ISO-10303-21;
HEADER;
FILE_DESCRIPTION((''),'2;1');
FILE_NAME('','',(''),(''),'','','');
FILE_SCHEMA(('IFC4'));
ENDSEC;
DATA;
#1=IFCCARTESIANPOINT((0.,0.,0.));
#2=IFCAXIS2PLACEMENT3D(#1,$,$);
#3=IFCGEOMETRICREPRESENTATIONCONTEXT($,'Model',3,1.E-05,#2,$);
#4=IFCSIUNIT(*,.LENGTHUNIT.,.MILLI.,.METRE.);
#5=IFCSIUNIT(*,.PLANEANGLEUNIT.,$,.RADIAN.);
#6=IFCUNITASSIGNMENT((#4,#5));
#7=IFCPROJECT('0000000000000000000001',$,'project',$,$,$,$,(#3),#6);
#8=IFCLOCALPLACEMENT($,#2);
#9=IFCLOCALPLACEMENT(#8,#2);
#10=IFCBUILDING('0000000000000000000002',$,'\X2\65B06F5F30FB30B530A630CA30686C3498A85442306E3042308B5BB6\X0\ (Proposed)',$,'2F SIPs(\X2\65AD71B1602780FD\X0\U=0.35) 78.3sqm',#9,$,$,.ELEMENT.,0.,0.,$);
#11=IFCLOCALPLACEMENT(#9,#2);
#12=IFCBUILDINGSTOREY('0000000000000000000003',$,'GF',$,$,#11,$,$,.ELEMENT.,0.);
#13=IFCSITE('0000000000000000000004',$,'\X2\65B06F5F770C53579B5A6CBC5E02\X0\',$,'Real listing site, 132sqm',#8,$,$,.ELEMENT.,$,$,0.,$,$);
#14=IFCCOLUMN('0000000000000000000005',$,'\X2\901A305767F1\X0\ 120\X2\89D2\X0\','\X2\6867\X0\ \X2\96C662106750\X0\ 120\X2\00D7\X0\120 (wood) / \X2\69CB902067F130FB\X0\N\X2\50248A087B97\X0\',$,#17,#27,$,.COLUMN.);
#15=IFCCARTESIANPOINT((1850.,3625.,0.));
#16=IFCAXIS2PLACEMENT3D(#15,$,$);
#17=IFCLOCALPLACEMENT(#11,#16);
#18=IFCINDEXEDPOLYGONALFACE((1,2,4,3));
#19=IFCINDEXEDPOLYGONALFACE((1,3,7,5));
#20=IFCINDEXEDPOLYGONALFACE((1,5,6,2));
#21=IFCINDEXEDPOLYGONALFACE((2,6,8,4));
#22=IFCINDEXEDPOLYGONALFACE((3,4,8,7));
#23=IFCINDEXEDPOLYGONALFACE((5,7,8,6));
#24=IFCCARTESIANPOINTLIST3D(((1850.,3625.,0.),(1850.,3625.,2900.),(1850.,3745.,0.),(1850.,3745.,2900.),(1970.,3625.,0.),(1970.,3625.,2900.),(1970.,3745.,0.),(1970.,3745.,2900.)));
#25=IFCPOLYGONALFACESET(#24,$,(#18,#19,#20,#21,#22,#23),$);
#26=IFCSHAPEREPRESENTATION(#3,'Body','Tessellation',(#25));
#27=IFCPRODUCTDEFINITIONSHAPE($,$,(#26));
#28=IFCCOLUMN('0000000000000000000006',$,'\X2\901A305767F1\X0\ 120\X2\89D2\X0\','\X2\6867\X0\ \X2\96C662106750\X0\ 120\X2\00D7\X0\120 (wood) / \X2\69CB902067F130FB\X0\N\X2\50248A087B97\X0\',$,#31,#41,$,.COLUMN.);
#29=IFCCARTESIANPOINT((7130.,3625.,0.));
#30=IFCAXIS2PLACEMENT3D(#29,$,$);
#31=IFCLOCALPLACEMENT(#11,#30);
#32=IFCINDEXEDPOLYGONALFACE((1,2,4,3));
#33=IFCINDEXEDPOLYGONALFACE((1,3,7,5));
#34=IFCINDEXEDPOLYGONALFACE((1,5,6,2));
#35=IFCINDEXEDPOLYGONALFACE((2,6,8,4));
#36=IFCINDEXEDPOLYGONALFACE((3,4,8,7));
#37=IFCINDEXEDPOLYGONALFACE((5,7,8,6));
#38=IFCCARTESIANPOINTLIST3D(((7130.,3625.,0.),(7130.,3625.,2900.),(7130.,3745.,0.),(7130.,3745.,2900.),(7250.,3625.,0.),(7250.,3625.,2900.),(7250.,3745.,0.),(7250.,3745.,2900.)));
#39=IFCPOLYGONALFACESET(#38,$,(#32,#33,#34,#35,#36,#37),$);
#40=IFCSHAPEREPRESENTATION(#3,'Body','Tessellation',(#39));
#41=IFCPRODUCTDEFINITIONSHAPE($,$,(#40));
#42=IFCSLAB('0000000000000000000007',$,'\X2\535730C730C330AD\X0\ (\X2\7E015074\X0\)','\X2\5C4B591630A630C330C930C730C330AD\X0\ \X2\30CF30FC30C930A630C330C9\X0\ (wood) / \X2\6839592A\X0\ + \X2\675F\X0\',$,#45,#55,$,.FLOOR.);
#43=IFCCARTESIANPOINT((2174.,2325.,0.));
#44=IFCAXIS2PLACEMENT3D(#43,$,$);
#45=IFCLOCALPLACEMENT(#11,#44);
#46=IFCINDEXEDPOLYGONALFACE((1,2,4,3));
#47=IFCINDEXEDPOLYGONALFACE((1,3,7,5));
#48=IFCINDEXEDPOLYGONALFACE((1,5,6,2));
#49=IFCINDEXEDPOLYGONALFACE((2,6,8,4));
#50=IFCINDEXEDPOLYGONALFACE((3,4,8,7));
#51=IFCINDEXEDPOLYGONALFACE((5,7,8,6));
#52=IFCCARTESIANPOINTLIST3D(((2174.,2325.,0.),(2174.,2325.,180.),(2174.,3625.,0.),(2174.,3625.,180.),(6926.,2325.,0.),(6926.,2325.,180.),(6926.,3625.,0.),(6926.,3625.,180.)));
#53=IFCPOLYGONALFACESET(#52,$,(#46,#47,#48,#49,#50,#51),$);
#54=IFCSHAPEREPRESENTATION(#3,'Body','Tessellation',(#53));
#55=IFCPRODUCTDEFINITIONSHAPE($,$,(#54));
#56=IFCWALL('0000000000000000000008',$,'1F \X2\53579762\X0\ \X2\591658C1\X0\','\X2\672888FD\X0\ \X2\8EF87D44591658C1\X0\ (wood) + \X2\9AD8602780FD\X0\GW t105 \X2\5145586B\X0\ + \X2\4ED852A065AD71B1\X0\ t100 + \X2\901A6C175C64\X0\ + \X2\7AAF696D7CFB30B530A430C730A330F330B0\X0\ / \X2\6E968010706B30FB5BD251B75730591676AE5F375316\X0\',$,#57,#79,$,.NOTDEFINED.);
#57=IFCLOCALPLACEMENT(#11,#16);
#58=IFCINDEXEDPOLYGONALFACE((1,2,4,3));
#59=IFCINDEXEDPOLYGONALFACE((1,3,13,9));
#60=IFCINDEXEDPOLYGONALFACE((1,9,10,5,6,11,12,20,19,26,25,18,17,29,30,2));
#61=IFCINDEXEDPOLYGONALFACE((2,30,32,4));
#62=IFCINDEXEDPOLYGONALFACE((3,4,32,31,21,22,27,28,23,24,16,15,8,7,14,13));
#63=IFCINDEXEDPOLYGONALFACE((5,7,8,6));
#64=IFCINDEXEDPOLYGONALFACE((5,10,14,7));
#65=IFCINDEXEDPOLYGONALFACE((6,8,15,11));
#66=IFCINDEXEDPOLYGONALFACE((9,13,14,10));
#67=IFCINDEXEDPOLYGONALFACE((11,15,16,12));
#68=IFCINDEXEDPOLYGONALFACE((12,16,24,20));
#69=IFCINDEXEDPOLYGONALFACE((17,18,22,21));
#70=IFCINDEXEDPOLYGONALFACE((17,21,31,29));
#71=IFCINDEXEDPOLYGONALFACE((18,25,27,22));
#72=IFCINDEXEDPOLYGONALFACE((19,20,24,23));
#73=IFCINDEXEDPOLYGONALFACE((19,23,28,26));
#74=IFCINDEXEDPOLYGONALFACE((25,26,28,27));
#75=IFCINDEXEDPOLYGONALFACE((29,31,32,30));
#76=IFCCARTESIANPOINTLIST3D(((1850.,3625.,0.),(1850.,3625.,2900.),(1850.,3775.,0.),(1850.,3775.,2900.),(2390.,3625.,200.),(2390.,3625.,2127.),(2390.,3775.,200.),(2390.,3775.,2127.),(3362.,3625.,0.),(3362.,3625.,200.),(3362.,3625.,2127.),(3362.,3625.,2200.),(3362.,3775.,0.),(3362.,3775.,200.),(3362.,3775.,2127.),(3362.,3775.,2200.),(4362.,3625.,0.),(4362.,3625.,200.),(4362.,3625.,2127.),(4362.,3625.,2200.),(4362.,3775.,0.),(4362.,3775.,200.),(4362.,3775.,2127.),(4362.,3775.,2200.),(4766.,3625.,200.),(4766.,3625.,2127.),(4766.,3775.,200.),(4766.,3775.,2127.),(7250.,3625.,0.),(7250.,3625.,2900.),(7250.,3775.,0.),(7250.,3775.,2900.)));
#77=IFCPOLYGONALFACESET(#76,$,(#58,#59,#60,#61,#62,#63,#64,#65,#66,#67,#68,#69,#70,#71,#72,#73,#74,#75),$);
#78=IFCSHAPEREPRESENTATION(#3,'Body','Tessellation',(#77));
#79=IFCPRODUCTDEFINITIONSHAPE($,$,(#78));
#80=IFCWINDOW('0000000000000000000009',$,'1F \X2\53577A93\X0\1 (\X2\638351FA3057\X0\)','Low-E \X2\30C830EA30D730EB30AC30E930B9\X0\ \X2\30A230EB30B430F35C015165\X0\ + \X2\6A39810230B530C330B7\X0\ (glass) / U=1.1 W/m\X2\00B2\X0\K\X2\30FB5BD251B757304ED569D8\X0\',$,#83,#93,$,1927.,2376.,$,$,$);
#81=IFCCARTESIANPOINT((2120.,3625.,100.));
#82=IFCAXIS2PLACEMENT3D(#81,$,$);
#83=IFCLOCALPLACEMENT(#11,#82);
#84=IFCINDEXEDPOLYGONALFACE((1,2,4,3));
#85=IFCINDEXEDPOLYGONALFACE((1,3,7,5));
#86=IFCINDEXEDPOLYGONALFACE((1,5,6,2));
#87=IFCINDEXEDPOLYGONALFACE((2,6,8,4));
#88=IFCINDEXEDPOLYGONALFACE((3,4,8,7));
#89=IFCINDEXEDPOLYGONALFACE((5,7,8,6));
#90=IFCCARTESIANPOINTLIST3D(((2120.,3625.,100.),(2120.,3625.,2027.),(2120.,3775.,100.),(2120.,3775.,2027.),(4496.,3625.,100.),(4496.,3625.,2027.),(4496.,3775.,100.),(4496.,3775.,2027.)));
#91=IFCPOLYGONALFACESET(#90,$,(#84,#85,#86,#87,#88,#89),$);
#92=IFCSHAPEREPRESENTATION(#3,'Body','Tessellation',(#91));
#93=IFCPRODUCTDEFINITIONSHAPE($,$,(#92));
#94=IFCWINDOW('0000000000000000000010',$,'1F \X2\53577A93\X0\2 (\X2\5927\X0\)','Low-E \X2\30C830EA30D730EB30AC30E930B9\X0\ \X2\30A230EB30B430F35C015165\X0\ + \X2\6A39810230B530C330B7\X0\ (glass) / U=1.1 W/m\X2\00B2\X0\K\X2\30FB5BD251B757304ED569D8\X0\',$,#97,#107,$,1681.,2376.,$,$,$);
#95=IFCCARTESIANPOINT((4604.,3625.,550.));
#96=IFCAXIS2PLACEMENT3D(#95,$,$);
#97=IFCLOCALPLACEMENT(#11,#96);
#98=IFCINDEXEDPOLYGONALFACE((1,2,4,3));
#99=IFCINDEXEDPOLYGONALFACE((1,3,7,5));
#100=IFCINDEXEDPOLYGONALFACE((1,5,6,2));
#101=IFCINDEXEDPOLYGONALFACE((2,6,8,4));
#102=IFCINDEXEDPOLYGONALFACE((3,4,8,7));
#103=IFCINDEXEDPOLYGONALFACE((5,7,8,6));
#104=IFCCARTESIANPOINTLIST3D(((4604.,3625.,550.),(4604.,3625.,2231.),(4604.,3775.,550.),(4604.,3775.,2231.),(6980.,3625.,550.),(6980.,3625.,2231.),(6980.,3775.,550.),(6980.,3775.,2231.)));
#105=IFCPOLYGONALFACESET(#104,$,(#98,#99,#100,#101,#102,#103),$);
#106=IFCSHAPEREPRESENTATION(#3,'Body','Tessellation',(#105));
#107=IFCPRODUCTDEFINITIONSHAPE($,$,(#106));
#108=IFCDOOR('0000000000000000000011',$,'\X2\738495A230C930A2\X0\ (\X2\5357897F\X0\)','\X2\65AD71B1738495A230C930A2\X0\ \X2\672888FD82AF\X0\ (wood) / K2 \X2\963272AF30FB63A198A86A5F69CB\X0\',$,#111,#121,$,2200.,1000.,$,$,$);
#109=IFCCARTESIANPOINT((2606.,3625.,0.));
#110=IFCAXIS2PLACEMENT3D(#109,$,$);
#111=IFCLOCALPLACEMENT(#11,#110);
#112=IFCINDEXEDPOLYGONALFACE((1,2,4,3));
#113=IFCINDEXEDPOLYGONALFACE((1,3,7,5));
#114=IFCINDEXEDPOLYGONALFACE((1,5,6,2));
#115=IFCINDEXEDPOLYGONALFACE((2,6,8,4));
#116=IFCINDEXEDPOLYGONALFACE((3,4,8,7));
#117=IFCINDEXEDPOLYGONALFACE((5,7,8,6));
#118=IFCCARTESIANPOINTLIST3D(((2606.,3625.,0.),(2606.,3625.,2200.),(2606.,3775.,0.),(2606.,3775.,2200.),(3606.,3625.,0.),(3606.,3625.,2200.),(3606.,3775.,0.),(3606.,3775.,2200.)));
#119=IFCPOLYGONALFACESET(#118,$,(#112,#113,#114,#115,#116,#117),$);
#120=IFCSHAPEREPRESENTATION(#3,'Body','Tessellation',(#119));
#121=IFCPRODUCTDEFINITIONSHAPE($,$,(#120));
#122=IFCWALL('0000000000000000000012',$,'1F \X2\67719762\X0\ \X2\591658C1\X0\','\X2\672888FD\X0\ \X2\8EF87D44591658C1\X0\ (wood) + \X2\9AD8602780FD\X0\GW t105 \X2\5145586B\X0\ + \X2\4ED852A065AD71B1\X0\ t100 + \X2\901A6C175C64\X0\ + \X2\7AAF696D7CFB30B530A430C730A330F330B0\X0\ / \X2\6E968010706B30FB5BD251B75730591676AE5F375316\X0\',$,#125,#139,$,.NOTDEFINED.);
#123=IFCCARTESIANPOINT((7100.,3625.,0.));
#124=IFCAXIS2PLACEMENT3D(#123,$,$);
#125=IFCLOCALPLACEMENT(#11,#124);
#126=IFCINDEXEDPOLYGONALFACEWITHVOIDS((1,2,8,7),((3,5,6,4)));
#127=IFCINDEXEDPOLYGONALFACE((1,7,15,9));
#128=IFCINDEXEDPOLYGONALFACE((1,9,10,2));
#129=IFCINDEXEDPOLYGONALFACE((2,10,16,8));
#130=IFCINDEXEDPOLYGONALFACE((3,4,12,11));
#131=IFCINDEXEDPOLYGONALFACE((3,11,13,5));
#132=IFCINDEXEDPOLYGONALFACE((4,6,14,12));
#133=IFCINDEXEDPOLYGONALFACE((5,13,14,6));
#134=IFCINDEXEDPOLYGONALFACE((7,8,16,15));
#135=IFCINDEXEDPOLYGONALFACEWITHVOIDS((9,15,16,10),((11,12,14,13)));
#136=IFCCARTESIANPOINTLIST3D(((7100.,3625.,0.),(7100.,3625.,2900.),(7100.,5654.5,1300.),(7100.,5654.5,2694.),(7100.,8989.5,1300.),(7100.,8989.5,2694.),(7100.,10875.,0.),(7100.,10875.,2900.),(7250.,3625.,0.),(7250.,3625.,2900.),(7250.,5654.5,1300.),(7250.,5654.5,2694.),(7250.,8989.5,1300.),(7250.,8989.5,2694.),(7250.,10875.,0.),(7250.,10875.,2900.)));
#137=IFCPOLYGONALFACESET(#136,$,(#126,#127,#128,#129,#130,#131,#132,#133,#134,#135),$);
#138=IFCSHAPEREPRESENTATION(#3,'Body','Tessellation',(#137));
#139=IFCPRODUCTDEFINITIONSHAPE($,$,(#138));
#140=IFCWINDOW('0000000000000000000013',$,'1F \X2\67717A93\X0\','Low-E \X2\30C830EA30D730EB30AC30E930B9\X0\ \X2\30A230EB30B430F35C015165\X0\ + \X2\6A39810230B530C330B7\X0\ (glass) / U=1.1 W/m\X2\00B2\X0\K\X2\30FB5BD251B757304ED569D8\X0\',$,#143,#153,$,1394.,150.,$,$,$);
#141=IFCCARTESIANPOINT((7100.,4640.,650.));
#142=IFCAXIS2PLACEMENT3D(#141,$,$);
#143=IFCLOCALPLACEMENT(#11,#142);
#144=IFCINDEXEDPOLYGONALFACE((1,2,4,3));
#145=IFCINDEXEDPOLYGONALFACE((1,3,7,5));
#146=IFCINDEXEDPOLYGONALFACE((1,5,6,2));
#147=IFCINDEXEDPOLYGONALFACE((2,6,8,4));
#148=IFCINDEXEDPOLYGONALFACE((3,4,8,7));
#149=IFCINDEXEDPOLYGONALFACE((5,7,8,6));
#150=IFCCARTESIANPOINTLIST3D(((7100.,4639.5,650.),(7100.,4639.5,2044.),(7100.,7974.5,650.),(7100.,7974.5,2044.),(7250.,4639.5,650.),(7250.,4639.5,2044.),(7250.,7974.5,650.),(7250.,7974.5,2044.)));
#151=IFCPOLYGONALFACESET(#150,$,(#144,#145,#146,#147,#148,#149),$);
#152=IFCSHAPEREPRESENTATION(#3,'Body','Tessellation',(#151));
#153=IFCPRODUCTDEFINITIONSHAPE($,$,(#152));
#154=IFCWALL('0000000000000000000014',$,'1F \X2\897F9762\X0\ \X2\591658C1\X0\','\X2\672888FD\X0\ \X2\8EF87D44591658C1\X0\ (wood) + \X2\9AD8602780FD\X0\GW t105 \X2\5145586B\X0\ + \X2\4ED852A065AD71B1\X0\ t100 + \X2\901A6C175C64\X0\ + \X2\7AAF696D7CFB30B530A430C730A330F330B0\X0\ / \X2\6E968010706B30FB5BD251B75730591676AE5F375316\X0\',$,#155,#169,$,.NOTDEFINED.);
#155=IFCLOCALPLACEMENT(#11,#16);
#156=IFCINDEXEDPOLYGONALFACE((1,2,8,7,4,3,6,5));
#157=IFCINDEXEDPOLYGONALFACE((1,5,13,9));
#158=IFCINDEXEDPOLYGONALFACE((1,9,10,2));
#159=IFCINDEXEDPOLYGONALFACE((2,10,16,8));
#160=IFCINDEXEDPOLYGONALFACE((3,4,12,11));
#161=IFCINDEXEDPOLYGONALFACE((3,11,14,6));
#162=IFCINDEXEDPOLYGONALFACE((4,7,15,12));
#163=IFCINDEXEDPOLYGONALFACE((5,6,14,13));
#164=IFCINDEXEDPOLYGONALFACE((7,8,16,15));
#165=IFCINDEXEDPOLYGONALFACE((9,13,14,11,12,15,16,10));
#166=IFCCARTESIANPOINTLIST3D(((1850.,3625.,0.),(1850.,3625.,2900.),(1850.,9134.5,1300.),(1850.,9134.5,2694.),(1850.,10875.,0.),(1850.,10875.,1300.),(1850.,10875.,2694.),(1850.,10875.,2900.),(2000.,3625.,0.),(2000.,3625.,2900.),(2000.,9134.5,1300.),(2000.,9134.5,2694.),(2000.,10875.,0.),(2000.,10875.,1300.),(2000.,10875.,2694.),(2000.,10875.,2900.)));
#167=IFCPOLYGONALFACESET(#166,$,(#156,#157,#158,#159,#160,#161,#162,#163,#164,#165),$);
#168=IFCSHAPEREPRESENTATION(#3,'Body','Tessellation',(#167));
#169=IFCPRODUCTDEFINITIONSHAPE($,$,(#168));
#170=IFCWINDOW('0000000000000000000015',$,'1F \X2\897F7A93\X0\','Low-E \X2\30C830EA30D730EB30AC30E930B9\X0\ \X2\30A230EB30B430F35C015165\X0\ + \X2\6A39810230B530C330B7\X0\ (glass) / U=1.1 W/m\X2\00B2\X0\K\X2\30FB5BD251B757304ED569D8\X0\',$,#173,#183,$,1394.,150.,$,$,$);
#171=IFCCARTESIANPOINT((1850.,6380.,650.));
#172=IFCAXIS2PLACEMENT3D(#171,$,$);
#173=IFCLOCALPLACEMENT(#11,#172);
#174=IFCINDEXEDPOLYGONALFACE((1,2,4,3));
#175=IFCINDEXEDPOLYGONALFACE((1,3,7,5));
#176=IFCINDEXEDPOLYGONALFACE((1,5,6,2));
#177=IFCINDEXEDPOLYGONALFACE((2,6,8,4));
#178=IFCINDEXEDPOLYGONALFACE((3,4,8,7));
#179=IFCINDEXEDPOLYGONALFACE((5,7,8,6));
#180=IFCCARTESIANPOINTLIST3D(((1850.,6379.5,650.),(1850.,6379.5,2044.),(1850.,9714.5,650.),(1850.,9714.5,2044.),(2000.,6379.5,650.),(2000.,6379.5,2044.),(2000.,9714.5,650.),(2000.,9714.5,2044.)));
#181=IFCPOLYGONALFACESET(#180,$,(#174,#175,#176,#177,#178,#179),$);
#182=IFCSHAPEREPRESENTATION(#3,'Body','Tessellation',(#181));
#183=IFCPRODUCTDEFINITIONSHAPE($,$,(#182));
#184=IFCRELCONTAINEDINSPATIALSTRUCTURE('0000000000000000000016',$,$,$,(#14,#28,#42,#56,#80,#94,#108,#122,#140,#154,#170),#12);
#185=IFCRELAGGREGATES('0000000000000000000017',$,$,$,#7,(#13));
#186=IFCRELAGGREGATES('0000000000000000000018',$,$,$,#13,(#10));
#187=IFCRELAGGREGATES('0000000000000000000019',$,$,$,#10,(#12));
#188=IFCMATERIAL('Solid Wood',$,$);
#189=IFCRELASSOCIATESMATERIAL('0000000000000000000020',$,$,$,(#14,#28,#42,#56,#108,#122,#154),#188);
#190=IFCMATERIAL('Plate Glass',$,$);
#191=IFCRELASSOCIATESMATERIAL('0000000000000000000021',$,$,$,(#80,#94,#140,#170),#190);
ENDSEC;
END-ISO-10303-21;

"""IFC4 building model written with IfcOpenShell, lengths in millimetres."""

from ifc_helpers import new_model, si_unit, frame, frame_2d, origin, place, context, project, spatial, rectangle, extrude, material, element, fill, save


model = new_model("IFC4")

# Units and contexts
model_context = context("Model", 3, precision=1e-05, world=origin())
ifc_project = project(units=[si_unit("LENGTHUNIT", "METRE", prefix="MILLI"), si_unit("PLANEANGLEUNIT", "RADIAN")], contexts=[model_context])

# Site, building, storey
site_placement = place(None, origin())
site = spatial("IfcSite", under=ifc_project, at=site_placement, Name="新潟県南魚沼市", ObjectType="Real listing site, 132sqm", CompositionType="ELEMENT", RefElevation=0.0)
building_placement = place(site_placement, origin())
building = spatial("IfcBuilding", under=site, at=building_placement, Name="新潟・サウナと水風呂のある家 (Proposed)", ObjectType="2F SIPs(断熱性能U=0.35) 78.3sqm", CompositionType="ELEMENT", ElevationOfRefHeight=0.0, ElevationOfTerrain=0.0)
storey_placement = place(building_placement, origin())
storey = spatial("IfcBuildingStorey", under=building, at=storey_placement, Name="GF", CompositionType="ELEMENT", Elevation=0.0)

# Columns
ifc_material_1 = material(Name="Solid Wood")
column_1_placement = place(storey_placement, frame((1850.0, 3625.0, 0.0)))
element("IfcColumn", 1, at=column_1_placement, inside=storey, material=ifc_material_1, Name="通し柱 120角", Description="桧 集成材 120×120 (wood) / 構造柱・N値計算", PredefinedType="COLUMN", context=model_context, shape_type="SweptSolid", body=[
    extrude(rectangle(XDim=120.0, YDim=120.0, at=frame_2d((60.0, 60.0))), frame((1850.0, 3625.0, 0.0)), (0.0, 0.0, 1.0), 2900.0),
])
column_2_placement = place(storey_placement, frame((7130.0, 3625.0, 0.0)))
element("IfcColumn", 2, at=column_2_placement, inside=storey, material=ifc_material_1, Name="通し柱 120角", Description="桧 集成材 120×120 (wood) / 構造柱・N値計算", PredefinedType="COLUMN", context=model_context, shape_type="SweptSolid", body=[
    extrude(rectangle(XDim=120.0, YDim=120.0, at=frame_2d((60.0, 60.0))), frame((7130.0, 3625.0, 0.0)), (0.0, 0.0, 1.0), 2900.0),
])

# Slab
slab_1_placement = place(storey_placement, frame((2174.0, 2325.0, 0.0)))
element("IfcSlab", 3, at=slab_1_placement, inside=storey, material=ifc_material_1, Name="南デッキ (縁側)", Description="屋外ウッドデッキ ハードウッド (wood) / 根太 + 束", PredefinedType="FLOOR", context=model_context, shape_type="SweptSolid", body=[
    extrude(rectangle(XDim=4752.0, YDim=1300.0, at=frame_2d((2376.0, 650.0))), frame((2174.0, 2325.0, 0.0)), (0.0, 0.0, 1.0), 180.0),
])

# Wall, openings, windows, door
wall_1_placement = place(storey_placement, frame((1850.0, 3625.0, 0.0)))
wall_1 = element("IfcWall", 4, at=wall_1_placement, inside=storey, material=ifc_material_1, Name="1F 南面 外壁", Description="木製 軸組外壁 (wood) + 高性能GW t105 充填 + 付加断熱 t100 + 通気層 + 窯業系サイディング / 準耐火・寒冷地外皮強化", PredefinedType="NOTDEFINED", context=model_context, shape_type="SweptSolid", body=[
    extrude(rectangle(XDim=5400.0, YDim=150.0, at=frame_2d((2700.0, 75.0))), frame((1850.0, 3625.0, 0.0)), (0.0, 0.0, 1.0), 2900.0),
])
opening_1_placement = place(storey_placement, frame((2120.0, 3625.0, 100.0)))
opening_1 = element("IfcOpeningElement", 5, at=opening_1_placement, cuts=wall_1, PredefinedType="NOTDEFINED", context=model_context, shape_type="SweptSolid", body=[
    extrude(rectangle(XDim=2376.0, YDim=150.0, at=frame_2d((1188.0, 75.0))), frame((2120.0, 3625.0, 100.0)), (0.0, 0.0, 1.0), 1927.0),
])
opening_2_placement = place(storey_placement, frame((4604.0, 3625.0, 550.0)))
opening_2 = element("IfcOpeningElement", 6, at=opening_2_placement, cuts=wall_1, PredefinedType="NOTDEFINED", context=model_context, shape_type="SweptSolid", body=[
    extrude(rectangle(XDim=2376.0, YDim=150.0, at=frame_2d((1188.0, 75.0))), frame((4604.0, 3625.0, 550.0)), (0.0, 0.0, 1.0), 1681.0),
])
opening_3_placement = place(storey_placement, frame((2606.0, 3625.0, 0.0)))
opening_3 = element("IfcOpeningElement", 7, at=opening_3_placement, cuts=wall_1, PredefinedType="NOTDEFINED", context=model_context, shape_type="SweptSolid", body=[
    extrude(rectangle(XDim=1000.0, YDim=150.0, at=frame_2d((500.0, 75.0))), frame((2606.0, 3625.0, 0.0)), (0.0, 0.0, 1.0), 2200.0),
])
ifc_material_2 = material(Name="Plate Glass")
window_1_placement = place(storey_placement, frame((2120.0, 3625.0, 100.0)))
window_1 = element("IfcWindow", 8, at=window_1_placement, inside=storey, material=ifc_material_2, Name="1F 南窓1 (掃出し)", Description="Low-E トリプルガラス アルゴン封入 + 樹脂サッシ (glass) / U=1.1 W/m²K・寒冷地仕様", OverallHeight=1927.0, OverallWidth=2376.0, context=model_context, shape_type="SweptSolid", body=[
    extrude(rectangle(XDim=2376.0, YDim=150.0, at=frame_2d((1188.0, 75.0))), frame((2120.0, 3625.0, 100.0)), (0.0, 0.0, 1.0), 1927.0),
])
fill(opening_1, window_1)
window_2_placement = place(storey_placement, frame((4604.0, 3625.0, 550.0)))
window_2 = element("IfcWindow", 9, at=window_2_placement, inside=storey, material=ifc_material_2, Name="1F 南窓2 (大)", Description="Low-E トリプルガラス アルゴン封入 + 樹脂サッシ (glass) / U=1.1 W/m²K・寒冷地仕様", OverallHeight=1681.0, OverallWidth=2376.0, context=model_context, shape_type="SweptSolid", body=[
    extrude(rectangle(XDim=2376.0, YDim=150.0, at=frame_2d((1188.0, 75.0))), frame((4604.0, 3625.0, 550.0)), (0.0, 0.0, 1.0), 1681.0),
])
fill(opening_2, window_2)
door_placement = place(storey_placement, frame((2606.0, 3625.0, 0.0)))
door = element("IfcDoor", 10, at=door_placement, inside=storey, material=ifc_material_1, Name="玄関ドア (南西)", Description="断熱玄関ドア 木製芯 (wood) / K2 防犯・採風機構", OverallHeight=2200.0, OverallWidth=1000.0, context=model_context, shape_type="SweptSolid", body=[
    extrude(rectangle(XDim=1000.0, YDim=150.0, at=frame_2d((500.0, 75.0))), frame((2606.0, 3625.0, 0.0)), (0.0, 0.0, 1.0), 2200.0),
])
fill(opening_3, door)

# Walls, openings, windows
wall_2_placement = place(storey_placement, frame((7100.0, 3625.0, 0.0)))
wall_2 = element("IfcWall", 11, at=wall_2_placement, inside=storey, material=ifc_material_1, Name="1F 東面 外壁", Description="木製 軸組外壁 (wood) + 高性能GW t105 充填 + 付加断熱 t100 + 通気層 + 窯業系サイディング / 準耐火・寒冷地外皮強化", PredefinedType="NOTDEFINED", context=model_context, shape_type="SweptSolid", body=[
    extrude(rectangle(XDim=150.0, YDim=7250.0, at=frame_2d((75.0, 3625.0))), frame((7100.0, 3625.0, 0.0)), (0.0, 0.0, 1.0), 2900.0),
])
opening_4_placement = place(storey_placement, frame((7100.0, 4640.0, 650.0)))
opening_4 = element("IfcOpeningElement", 12, at=opening_4_placement, cuts=wall_2, PredefinedType="NOTDEFINED", context=model_context, shape_type="SweptSolid", body=[
    extrude(rectangle(XDim=150.0, YDim=3335.0, at=frame_2d((75.0, 1667.0))), frame((7100.0, 4640.0, 650.0)), (0.0, 0.0, 1.0), 1394.0),
])
window_3_placement = place(storey_placement, frame((7100.0, 4640.0, 650.0)))
window_3 = element("IfcWindow", 13, at=window_3_placement, inside=storey, material=ifc_material_2, Name="1F 東窓", Description="Low-E トリプルガラス アルゴン封入 + 樹脂サッシ (glass) / U=1.1 W/m²K・寒冷地仕様", OverallHeight=1394.0, OverallWidth=150.0, context=model_context, shape_type="SweptSolid", body=[
    extrude(rectangle(XDim=150.0, YDim=3335.0, at=frame_2d((75.0, 1667.0))), frame((7100.0, 4640.0, 650.0)), (0.0, 0.0, 1.0), 1394.0),
])
fill(opening_4, window_3)
wall_3_placement = place(storey_placement, frame((1850.0, 3625.0, 0.0)))
wall_3 = element("IfcWall", 14, at=wall_3_placement, inside=storey, material=ifc_material_1, Name="1F 西面 外壁", Description="木製 軸組外壁 (wood) + 高性能GW t105 充填 + 付加断熱 t100 + 通気層 + 窯業系サイディング / 準耐火・寒冷地外皮強化", PredefinedType="NOTDEFINED", context=model_context, shape_type="SweptSolid", body=[
    extrude(rectangle(XDim=150.0, YDim=7250.0, at=frame_2d((75.0, 3625.0))), frame((1850.0, 3625.0, 0.0)), (0.0, 0.0, 1.0), 2900.0),
])
opening_5_placement = place(storey_placement, frame((1850.0, 6380.0, 650.0)))
opening_5 = element("IfcOpeningElement", 15, at=opening_5_placement, cuts=wall_3, PredefinedType="NOTDEFINED", context=model_context, shape_type="SweptSolid", body=[
    extrude(rectangle(XDim=150.0, YDim=3335.0, at=frame_2d((75.0, 1667.0))), frame((1850.0, 6380.0, 650.0)), (0.0, 0.0, 1.0), 1394.0),
])
window_4_placement = place(storey_placement, frame((1850.0, 6380.0, 650.0)))
window_4 = element("IfcWindow", 16, at=window_4_placement, inside=storey, material=ifc_material_2, Name="1F 西窓", Description="Low-E トリプルガラス アルゴン封入 + 樹脂サッシ (glass) / U=1.1 W/m²K・寒冷地仕様", OverallHeight=1394.0, OverallWidth=150.0, context=model_context, shape_type="SweptSolid", body=[
    extrude(rectangle(XDim=150.0, YDim=3335.0, at=frame_2d((75.0, 1667.0))), frame((1850.0, 6380.0, 650.0)), (0.0, 0.0, 1.0), 1394.0),
])
fill(opening_5, window_4)

save(model, "model.ifc")
